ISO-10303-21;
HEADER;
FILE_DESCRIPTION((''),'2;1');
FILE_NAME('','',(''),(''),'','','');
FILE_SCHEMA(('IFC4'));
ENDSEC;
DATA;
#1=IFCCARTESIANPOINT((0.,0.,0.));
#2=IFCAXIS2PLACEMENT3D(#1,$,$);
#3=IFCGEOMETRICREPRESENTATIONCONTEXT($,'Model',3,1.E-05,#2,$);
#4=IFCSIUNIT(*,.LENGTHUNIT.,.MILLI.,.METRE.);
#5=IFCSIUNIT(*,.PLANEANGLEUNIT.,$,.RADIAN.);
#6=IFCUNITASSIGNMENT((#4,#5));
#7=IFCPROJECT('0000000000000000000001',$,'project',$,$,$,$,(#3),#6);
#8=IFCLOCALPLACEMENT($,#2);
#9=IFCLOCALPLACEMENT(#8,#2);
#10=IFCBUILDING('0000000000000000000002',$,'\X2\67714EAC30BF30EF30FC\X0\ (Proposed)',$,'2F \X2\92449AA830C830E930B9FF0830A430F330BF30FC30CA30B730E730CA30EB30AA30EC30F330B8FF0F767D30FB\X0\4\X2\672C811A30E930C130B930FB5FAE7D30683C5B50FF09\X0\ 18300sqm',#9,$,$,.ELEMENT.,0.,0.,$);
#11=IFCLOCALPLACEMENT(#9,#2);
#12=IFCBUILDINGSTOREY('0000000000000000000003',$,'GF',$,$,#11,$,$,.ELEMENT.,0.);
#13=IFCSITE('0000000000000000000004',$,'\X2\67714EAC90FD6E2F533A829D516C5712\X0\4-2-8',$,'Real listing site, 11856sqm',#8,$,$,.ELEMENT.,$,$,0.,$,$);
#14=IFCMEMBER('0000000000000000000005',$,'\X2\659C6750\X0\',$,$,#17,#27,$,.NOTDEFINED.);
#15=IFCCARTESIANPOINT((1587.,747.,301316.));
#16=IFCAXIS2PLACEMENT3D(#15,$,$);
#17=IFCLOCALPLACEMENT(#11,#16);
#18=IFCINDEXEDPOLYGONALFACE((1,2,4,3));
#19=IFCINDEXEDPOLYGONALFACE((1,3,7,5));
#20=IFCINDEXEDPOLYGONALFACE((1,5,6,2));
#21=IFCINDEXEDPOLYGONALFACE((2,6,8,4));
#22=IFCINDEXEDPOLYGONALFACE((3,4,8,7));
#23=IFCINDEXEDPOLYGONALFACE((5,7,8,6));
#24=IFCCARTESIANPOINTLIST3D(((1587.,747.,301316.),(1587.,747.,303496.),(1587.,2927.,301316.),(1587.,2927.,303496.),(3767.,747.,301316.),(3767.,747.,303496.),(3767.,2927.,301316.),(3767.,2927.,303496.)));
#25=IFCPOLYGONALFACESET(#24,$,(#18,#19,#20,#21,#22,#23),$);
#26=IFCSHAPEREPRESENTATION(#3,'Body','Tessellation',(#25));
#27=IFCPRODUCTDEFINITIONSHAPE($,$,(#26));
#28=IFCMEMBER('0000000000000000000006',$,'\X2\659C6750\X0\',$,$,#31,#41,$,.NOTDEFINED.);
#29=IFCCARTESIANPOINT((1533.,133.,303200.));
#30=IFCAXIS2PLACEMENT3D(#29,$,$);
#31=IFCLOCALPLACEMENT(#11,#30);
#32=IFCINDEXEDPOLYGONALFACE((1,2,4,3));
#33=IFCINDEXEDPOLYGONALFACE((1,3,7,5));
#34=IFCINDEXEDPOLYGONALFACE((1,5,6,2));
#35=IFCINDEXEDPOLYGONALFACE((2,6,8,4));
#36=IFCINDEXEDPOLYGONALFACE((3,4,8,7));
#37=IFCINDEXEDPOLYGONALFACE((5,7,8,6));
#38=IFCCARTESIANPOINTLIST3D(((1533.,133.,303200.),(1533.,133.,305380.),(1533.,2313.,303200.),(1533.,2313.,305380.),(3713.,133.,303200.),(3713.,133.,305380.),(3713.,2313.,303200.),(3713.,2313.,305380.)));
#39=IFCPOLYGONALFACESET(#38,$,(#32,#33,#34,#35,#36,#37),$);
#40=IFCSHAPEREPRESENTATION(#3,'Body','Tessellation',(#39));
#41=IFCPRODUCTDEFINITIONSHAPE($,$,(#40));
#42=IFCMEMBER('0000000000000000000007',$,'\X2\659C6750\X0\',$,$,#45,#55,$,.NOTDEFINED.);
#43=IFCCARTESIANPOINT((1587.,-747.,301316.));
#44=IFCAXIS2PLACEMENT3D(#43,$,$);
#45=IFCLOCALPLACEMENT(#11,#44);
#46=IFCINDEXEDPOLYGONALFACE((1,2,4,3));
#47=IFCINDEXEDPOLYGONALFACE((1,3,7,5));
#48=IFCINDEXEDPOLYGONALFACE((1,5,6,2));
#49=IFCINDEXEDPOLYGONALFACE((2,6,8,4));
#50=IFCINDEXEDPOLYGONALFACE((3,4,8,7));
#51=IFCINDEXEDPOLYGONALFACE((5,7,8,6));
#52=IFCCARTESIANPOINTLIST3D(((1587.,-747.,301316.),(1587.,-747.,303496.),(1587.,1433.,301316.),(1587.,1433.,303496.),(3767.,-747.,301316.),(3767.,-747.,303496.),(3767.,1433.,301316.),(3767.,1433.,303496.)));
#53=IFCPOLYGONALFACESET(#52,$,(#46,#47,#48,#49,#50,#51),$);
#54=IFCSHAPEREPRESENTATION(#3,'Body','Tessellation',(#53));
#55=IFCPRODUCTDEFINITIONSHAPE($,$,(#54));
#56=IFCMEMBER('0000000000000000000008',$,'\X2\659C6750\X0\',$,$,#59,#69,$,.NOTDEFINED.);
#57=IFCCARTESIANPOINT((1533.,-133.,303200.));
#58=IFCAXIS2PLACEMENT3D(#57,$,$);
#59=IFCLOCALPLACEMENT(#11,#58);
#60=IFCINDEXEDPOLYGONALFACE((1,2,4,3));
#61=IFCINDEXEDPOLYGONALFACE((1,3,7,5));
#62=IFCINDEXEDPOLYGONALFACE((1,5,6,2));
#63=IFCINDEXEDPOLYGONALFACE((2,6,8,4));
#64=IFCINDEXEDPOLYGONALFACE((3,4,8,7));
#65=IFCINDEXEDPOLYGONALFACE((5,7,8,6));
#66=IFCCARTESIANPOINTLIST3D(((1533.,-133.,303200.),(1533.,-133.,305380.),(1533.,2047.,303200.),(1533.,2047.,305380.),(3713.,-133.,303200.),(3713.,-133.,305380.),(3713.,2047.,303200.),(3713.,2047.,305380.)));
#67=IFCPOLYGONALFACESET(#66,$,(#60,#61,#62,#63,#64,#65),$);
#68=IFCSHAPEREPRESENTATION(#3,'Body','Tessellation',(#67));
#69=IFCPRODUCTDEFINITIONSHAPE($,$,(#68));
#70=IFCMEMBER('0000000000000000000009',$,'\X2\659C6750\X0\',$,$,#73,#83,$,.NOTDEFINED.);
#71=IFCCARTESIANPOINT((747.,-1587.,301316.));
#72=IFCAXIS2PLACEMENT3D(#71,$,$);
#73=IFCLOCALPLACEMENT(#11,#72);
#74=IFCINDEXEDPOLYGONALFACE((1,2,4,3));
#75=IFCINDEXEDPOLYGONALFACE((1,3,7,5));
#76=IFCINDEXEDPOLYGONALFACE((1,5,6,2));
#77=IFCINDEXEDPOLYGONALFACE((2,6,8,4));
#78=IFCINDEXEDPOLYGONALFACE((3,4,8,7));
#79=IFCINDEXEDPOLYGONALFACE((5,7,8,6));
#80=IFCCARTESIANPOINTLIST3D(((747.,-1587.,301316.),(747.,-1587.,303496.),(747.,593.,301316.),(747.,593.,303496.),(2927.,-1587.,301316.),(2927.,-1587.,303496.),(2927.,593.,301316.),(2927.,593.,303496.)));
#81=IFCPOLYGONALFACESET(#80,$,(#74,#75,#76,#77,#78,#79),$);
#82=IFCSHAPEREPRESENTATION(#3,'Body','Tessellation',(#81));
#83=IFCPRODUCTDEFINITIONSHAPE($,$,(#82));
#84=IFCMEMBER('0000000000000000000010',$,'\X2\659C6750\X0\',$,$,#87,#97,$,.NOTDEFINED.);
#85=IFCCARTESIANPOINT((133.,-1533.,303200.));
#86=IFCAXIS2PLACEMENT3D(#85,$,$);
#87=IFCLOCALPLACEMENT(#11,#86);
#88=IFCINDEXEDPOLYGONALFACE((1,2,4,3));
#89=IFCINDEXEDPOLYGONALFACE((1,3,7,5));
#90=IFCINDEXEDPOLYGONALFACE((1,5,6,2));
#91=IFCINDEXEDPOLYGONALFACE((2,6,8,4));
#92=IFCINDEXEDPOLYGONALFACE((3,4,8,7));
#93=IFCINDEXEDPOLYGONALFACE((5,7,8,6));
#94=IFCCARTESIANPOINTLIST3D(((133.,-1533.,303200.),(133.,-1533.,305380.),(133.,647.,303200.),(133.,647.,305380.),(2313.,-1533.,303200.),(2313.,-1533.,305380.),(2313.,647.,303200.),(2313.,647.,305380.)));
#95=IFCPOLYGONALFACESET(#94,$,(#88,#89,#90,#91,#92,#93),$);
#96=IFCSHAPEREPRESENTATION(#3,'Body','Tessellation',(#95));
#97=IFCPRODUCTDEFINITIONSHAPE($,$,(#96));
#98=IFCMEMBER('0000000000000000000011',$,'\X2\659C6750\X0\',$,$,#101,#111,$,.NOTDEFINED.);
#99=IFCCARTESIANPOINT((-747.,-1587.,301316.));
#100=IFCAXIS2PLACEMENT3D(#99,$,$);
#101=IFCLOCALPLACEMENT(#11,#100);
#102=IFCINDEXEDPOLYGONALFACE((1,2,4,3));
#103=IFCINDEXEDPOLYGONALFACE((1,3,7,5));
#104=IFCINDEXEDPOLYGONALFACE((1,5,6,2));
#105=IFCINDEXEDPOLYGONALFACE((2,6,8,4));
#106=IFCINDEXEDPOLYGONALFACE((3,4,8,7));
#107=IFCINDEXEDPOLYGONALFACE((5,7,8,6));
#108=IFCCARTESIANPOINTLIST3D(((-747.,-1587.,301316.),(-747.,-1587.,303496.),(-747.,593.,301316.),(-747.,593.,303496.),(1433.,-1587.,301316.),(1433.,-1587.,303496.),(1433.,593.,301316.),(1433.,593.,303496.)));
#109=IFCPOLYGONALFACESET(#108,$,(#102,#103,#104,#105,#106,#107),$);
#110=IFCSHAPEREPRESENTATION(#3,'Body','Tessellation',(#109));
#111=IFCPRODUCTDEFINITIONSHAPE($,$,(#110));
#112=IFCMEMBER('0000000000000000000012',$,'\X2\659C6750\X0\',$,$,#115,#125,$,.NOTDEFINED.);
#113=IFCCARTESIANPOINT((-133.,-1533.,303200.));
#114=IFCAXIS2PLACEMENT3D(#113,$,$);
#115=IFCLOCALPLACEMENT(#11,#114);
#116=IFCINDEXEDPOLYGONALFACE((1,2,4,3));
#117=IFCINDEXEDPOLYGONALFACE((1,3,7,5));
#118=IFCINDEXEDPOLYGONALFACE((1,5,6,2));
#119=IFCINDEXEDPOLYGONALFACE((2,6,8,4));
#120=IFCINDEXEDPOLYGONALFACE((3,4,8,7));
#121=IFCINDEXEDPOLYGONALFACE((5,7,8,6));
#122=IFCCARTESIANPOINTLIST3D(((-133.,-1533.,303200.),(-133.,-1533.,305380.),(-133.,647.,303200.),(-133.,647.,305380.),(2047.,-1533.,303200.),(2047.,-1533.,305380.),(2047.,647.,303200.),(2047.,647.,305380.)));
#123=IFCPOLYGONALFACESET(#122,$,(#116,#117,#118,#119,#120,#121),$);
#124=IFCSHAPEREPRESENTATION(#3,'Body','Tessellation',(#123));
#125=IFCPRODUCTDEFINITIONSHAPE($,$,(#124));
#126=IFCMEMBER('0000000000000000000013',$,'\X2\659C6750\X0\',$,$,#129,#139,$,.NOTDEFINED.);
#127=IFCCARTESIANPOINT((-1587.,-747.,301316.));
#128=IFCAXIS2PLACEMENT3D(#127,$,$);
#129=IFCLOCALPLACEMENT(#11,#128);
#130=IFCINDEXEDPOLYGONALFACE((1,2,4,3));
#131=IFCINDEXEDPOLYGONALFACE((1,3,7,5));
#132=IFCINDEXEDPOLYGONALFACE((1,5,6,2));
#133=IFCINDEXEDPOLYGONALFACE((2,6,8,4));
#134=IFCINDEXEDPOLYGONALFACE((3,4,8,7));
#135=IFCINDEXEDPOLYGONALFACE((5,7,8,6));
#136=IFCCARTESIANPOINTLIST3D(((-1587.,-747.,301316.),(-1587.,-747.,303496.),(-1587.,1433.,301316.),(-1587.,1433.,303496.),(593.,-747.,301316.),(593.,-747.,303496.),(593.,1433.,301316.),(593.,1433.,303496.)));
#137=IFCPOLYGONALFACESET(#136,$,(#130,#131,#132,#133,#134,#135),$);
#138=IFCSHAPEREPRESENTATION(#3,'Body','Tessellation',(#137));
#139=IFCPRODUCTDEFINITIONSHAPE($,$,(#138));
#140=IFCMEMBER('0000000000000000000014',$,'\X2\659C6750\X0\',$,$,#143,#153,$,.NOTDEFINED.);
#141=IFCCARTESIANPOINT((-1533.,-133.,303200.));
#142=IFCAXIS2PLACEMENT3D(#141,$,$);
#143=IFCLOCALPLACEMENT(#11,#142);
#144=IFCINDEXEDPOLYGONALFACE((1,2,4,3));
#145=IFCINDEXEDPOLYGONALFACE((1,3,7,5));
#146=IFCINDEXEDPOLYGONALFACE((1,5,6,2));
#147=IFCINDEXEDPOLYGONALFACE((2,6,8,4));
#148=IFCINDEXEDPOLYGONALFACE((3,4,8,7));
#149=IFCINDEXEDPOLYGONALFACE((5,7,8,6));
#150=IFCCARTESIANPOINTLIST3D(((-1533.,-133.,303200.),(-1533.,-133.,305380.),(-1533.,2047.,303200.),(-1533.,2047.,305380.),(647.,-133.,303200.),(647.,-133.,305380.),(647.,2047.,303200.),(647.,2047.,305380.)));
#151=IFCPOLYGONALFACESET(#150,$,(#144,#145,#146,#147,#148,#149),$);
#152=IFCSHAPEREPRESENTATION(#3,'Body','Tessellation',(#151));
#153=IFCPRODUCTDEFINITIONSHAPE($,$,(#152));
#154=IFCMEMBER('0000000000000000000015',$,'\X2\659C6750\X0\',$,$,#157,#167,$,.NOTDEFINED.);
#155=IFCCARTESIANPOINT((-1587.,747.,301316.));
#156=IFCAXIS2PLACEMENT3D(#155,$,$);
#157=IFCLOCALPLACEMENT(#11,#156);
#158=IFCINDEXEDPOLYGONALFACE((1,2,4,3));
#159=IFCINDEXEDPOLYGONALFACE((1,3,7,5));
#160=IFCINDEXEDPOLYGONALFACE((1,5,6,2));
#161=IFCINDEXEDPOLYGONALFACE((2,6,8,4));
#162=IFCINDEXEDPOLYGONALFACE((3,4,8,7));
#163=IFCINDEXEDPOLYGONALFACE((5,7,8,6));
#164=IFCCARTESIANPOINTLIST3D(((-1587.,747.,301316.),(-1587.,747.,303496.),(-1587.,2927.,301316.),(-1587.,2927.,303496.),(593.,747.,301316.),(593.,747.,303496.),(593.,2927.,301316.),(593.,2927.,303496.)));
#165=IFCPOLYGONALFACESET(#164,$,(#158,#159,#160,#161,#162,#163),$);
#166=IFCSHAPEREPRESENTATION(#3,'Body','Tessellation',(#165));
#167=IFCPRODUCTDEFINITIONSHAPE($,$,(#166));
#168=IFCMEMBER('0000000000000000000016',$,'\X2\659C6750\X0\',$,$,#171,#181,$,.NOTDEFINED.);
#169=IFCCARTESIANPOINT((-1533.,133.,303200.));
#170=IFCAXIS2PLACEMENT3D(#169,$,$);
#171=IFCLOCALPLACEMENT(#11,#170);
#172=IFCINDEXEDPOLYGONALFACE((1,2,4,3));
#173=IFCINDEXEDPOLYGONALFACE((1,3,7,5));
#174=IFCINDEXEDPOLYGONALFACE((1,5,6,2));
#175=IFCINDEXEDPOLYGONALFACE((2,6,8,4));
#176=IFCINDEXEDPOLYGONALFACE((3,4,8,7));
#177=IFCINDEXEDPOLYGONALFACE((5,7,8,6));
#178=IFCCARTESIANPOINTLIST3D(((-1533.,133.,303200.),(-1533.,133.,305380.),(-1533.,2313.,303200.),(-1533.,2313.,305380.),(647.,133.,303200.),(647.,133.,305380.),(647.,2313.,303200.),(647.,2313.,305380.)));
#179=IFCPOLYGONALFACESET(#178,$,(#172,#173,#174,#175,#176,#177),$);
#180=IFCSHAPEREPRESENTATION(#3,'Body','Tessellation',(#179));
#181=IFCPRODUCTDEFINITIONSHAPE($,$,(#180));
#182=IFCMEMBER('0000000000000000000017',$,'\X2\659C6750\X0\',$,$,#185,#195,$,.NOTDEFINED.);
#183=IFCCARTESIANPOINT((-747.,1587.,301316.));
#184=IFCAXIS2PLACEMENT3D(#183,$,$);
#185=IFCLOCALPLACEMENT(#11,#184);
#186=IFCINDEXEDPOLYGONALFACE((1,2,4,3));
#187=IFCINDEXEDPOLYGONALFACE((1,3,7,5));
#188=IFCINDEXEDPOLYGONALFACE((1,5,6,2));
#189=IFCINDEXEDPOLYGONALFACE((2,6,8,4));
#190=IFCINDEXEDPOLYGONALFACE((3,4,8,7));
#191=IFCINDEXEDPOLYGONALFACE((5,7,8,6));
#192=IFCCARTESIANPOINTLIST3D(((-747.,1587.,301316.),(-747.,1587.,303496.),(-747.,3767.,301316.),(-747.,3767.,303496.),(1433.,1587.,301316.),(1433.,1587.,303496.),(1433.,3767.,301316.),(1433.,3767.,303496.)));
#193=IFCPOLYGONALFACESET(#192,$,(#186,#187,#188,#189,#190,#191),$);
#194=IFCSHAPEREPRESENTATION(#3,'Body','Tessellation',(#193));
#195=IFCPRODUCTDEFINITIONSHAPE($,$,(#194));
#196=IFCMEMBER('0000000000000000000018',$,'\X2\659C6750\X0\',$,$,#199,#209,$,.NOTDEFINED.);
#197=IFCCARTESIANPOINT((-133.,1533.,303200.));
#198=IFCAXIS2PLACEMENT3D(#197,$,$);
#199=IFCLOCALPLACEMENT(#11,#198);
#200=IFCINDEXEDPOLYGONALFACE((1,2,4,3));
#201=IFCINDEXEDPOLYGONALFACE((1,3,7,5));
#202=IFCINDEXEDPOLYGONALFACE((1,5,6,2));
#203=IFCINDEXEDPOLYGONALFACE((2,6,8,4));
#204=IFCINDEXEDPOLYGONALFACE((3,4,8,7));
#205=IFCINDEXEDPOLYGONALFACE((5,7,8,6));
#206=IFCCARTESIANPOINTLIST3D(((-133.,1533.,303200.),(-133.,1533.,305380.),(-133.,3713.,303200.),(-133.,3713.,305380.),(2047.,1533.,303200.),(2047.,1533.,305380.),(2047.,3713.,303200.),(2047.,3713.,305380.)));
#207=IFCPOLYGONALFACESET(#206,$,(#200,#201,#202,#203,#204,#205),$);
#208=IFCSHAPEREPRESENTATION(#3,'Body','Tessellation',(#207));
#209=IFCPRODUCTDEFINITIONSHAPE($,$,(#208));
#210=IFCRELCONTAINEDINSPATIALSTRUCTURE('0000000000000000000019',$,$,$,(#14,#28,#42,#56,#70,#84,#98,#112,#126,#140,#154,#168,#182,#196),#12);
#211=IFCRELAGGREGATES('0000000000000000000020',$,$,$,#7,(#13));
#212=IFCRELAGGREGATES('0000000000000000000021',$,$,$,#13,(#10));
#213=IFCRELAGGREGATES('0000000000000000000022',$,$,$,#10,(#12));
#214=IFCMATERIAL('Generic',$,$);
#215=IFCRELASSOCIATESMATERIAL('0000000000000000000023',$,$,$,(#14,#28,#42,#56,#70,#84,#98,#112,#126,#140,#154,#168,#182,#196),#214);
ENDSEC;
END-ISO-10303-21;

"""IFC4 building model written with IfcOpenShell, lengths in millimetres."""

from ifc_helpers import new_model, si_unit, frame, frame_2d, origin, place, context, project, spatial, rectangle, extrude, material, element, save


model = new_model("IFC4")

# Units and contexts
model_context = context("Model", 3, precision=1e-05, world=origin())
ifc_project = project(units=[si_unit("LENGTHUNIT", "METRE", prefix="MILLI"), si_unit("PLANEANGLEUNIT", "RADIAN")], contexts=[model_context])

# Site, building, storey
site_placement = place(None, origin())
site = spatial("IfcSite", under=ifc_project, at=site_placement, Name="東京都港区芝公園4-2-8", ObjectType="Real listing site, 11856sqm", CompositionType="ELEMENT", RefElevation=0.0)
building_placement = place(site_placement, origin())
building = spatial("IfcBuilding", under=site, at=building_placement, Name="東京タワー (Proposed)", ObjectType="2F 鉄骨トラス（インターナショナルオレンジ／白・4本脚ラチス・微細格子） 18300sqm", CompositionType="ELEMENT", ElevationOfRefHeight=0.0, ElevationOfTerrain=0.0)
storey_placement = place(building_placement, origin())
storey = spatial("IfcBuildingStorey", under=building, at=storey_placement, Name="GF", CompositionType="ELEMENT", Elevation=0.0)

# Shared definitions
ifc_material = material(Name="Generic")

# Members
member_1_placement = place(storey_placement, frame((1587.0, 747.0, 301316.0)))
element("IfcMember", 1, at=member_1_placement, inside=storey, material=ifc_material, Name="斜材", PredefinedType="NOTDEFINED", context=model_context, shape_type="SweptSolid", body=[
    extrude(rectangle(XDim=2180.0, YDim=2180.0, at=frame_2d((1090.0, 1090.0))), frame((1587.0, 747.0, 301316.0)), (0.0, 0.0, 1.0), 2180.0),
])
member_2_placement = place(storey_placement, frame((1533.0, 133.0, 303200.0)))
element("IfcMember", 2, at=member_2_placement, inside=storey, material=ifc_material, Name="斜材", PredefinedType="NOTDEFINED", context=model_context, shape_type="SweptSolid", body=[
    extrude(rectangle(XDim=2180.0, YDim=2180.0, at=frame_2d((1090.0, 1090.0))), frame((1533.0, 133.0, 303200.0)), (0.0, 0.0, 1.0), 2180.0),
])
member_3_placement = place(storey_placement, frame((1587.0, -747.0, 301316.0)))
element("IfcMember", 3, at=member_3_placement, inside=storey, material=ifc_material, Name="斜材", PredefinedType="NOTDEFINED", context=model_context, shape_type="SweptSolid", body=[
    extrude(rectangle(XDim=2180.0, YDim=2180.0, at=frame_2d((1090.0, 1090.0))), frame((1587.0, -747.0, 301316.0)), (0.0, 0.0, 1.0), 2180.0),
])
member_4_placement = place(storey_placement, frame((1533.0, -133.0, 303200.0)))
element("IfcMember", 4, at=member_4_placement, inside=storey, material=ifc_material, Name="斜材", PredefinedType="NOTDEFINED", context=model_context, shape_type="SweptSolid", body=[
    extrude(rectangle(XDim=2180.0, YDim=2180.0, at=frame_2d((1090.0, 1090.0))), frame((1533.0, -133.0, 303200.0)), (0.0, 0.0, 1.0), 2180.0),
])
member_5_placement = place(storey_placement, frame((747.0, -1587.0, 301316.0)))
element("IfcMember", 5, at=member_5_placement, inside=storey, material=ifc_material, Name="斜材", PredefinedType="NOTDEFINED", context=model_context, shape_type="SweptSolid", body=[
    extrude(rectangle(XDim=2180.0, YDim=2180.0, at=frame_2d((1090.0, 1090.0))), frame((747.0, -1587.0, 301316.0)), (0.0, 0.0, 1.0), 2180.0),
])
member_6_placement = place(storey_placement, frame((133.0, -1533.0, 303200.0)))
element("IfcMember", 6, at=member_6_placement, inside=storey, material=ifc_material, Name="斜材", PredefinedType="NOTDEFINED", context=model_context, shape_type="SweptSolid", body=[
    extrude(rectangle(XDim=2180.0, YDim=2180.0, at=frame_2d((1090.0, 1090.0))), frame((133.0, -1533.0, 303200.0)), (0.0, 0.0, 1.0), 2180.0),
])
member_7_placement = place(storey_placement, frame((-747.0, -1587.0, 301316.0)))
element("IfcMember", 7, at=member_7_placement, inside=storey, material=ifc_material, Name="斜材", PredefinedType="NOTDEFINED", context=model_context, shape_type="SweptSolid", body=[
    extrude(rectangle(XDim=2180.0, YDim=2180.0, at=frame_2d((1090.0, 1090.0))), frame((-747.0, -1587.0, 301316.0)), (0.0, 0.0, 1.0), 2180.0),
])
member_8_placement = place(storey_placement, frame((-133.0, -1533.0, 303200.0)))
element("IfcMember", 8, at=member_8_placement, inside=storey, material=ifc_material, Name="斜材", PredefinedType="NOTDEFINED", context=model_context, shape_type="SweptSolid", body=[
    extrude(rectangle(XDim=2180.0, YDim=2180.0, at=frame_2d((1090.0, 1090.0))), frame((-133.0, -1533.0, 303200.0)), (0.0, 0.0, 1.0), 2180.0),
])
member_9_placement = place(storey_placement, frame((-1587.0, -747.0, 301316.0)))
element("IfcMember", 9, at=member_9_placement, inside=storey, material=ifc_material, Name="斜材", PredefinedType="NOTDEFINED", context=model_context, shape_type="SweptSolid", body=[
    extrude(rectangle(XDim=2180.0, YDim=2180.0, at=frame_2d((1090.0, 1090.0))), frame((-1587.0, -747.0, 301316.0)), (0.0, 0.0, 1.0), 2180.0),
])
member_10_placement = place(storey_placement, frame((-1533.0, -133.0, 303200.0)))
element("IfcMember", 10, at=member_10_placement, inside=storey, material=ifc_material, Name="斜材", PredefinedType="NOTDEFINED", context=model_context, shape_type="SweptSolid", body=[
    extrude(rectangle(XDim=2180.0, YDim=2180.0, at=frame_2d((1090.0, 1090.0))), frame((-1533.0, -133.0, 303200.0)), (0.0, 0.0, 1.0), 2180.0),
])
member_11_placement = place(storey_placement, frame((-1587.0, 747.0, 301316.0)))
element("IfcMember", 11, at=member_11_placement, inside=storey, material=ifc_material, Name="斜材", PredefinedType="NOTDEFINED", context=model_context, shape_type="SweptSolid", body=[
    extrude(rectangle(XDim=2180.0, YDim=2180.0, at=frame_2d((1090.0, 1090.0))), frame((-1587.0, 747.0, 301316.0)), (0.0, 0.0, 1.0), 2180.0),
])
member_12_placement = place(storey_placement, frame((-1533.0, 133.0, 303200.0)))
element("IfcMember", 12, at=member_12_placement, inside=storey, material=ifc_material, Name="斜材", PredefinedType="NOTDEFINED", context=model_context, shape_type="SweptSolid", body=[
    extrude(rectangle(XDim=2180.0, YDim=2180.0, at=frame_2d((1090.0, 1090.0))), frame((-1533.0, 133.0, 303200.0)), (0.0, 0.0, 1.0), 2180.0),
])
member_13_placement = place(storey_placement, frame((-747.0, 1587.0, 301316.0)))
element("IfcMember", 13, at=member_13_placement, inside=storey, material=ifc_material, Name="斜材", PredefinedType="NOTDEFINED", context=model_context, shape_type="SweptSolid", body=[
    extrude(rectangle(XDim=2180.0, YDim=2180.0, at=frame_2d((1090.0, 1090.0))), frame((-747.0, 1587.0, 301316.0)), (0.0, 0.0, 1.0), 2180.0),
])
member_14_placement = place(storey_placement, frame((-133.0, 1533.0, 303200.0)))
element("IfcMember", 14, at=member_14_placement, inside=storey, material=ifc_material, Name="斜材", PredefinedType="NOTDEFINED", context=model_context, shape_type="SweptSolid", body=[
    extrude(rectangle(XDim=2180.0, YDim=2180.0, at=frame_2d((1090.0, 1090.0))), frame((-133.0, 1533.0, 303200.0)), (0.0, 0.0, 1.0), 2180.0),
])

save(model, "model.ifc")
